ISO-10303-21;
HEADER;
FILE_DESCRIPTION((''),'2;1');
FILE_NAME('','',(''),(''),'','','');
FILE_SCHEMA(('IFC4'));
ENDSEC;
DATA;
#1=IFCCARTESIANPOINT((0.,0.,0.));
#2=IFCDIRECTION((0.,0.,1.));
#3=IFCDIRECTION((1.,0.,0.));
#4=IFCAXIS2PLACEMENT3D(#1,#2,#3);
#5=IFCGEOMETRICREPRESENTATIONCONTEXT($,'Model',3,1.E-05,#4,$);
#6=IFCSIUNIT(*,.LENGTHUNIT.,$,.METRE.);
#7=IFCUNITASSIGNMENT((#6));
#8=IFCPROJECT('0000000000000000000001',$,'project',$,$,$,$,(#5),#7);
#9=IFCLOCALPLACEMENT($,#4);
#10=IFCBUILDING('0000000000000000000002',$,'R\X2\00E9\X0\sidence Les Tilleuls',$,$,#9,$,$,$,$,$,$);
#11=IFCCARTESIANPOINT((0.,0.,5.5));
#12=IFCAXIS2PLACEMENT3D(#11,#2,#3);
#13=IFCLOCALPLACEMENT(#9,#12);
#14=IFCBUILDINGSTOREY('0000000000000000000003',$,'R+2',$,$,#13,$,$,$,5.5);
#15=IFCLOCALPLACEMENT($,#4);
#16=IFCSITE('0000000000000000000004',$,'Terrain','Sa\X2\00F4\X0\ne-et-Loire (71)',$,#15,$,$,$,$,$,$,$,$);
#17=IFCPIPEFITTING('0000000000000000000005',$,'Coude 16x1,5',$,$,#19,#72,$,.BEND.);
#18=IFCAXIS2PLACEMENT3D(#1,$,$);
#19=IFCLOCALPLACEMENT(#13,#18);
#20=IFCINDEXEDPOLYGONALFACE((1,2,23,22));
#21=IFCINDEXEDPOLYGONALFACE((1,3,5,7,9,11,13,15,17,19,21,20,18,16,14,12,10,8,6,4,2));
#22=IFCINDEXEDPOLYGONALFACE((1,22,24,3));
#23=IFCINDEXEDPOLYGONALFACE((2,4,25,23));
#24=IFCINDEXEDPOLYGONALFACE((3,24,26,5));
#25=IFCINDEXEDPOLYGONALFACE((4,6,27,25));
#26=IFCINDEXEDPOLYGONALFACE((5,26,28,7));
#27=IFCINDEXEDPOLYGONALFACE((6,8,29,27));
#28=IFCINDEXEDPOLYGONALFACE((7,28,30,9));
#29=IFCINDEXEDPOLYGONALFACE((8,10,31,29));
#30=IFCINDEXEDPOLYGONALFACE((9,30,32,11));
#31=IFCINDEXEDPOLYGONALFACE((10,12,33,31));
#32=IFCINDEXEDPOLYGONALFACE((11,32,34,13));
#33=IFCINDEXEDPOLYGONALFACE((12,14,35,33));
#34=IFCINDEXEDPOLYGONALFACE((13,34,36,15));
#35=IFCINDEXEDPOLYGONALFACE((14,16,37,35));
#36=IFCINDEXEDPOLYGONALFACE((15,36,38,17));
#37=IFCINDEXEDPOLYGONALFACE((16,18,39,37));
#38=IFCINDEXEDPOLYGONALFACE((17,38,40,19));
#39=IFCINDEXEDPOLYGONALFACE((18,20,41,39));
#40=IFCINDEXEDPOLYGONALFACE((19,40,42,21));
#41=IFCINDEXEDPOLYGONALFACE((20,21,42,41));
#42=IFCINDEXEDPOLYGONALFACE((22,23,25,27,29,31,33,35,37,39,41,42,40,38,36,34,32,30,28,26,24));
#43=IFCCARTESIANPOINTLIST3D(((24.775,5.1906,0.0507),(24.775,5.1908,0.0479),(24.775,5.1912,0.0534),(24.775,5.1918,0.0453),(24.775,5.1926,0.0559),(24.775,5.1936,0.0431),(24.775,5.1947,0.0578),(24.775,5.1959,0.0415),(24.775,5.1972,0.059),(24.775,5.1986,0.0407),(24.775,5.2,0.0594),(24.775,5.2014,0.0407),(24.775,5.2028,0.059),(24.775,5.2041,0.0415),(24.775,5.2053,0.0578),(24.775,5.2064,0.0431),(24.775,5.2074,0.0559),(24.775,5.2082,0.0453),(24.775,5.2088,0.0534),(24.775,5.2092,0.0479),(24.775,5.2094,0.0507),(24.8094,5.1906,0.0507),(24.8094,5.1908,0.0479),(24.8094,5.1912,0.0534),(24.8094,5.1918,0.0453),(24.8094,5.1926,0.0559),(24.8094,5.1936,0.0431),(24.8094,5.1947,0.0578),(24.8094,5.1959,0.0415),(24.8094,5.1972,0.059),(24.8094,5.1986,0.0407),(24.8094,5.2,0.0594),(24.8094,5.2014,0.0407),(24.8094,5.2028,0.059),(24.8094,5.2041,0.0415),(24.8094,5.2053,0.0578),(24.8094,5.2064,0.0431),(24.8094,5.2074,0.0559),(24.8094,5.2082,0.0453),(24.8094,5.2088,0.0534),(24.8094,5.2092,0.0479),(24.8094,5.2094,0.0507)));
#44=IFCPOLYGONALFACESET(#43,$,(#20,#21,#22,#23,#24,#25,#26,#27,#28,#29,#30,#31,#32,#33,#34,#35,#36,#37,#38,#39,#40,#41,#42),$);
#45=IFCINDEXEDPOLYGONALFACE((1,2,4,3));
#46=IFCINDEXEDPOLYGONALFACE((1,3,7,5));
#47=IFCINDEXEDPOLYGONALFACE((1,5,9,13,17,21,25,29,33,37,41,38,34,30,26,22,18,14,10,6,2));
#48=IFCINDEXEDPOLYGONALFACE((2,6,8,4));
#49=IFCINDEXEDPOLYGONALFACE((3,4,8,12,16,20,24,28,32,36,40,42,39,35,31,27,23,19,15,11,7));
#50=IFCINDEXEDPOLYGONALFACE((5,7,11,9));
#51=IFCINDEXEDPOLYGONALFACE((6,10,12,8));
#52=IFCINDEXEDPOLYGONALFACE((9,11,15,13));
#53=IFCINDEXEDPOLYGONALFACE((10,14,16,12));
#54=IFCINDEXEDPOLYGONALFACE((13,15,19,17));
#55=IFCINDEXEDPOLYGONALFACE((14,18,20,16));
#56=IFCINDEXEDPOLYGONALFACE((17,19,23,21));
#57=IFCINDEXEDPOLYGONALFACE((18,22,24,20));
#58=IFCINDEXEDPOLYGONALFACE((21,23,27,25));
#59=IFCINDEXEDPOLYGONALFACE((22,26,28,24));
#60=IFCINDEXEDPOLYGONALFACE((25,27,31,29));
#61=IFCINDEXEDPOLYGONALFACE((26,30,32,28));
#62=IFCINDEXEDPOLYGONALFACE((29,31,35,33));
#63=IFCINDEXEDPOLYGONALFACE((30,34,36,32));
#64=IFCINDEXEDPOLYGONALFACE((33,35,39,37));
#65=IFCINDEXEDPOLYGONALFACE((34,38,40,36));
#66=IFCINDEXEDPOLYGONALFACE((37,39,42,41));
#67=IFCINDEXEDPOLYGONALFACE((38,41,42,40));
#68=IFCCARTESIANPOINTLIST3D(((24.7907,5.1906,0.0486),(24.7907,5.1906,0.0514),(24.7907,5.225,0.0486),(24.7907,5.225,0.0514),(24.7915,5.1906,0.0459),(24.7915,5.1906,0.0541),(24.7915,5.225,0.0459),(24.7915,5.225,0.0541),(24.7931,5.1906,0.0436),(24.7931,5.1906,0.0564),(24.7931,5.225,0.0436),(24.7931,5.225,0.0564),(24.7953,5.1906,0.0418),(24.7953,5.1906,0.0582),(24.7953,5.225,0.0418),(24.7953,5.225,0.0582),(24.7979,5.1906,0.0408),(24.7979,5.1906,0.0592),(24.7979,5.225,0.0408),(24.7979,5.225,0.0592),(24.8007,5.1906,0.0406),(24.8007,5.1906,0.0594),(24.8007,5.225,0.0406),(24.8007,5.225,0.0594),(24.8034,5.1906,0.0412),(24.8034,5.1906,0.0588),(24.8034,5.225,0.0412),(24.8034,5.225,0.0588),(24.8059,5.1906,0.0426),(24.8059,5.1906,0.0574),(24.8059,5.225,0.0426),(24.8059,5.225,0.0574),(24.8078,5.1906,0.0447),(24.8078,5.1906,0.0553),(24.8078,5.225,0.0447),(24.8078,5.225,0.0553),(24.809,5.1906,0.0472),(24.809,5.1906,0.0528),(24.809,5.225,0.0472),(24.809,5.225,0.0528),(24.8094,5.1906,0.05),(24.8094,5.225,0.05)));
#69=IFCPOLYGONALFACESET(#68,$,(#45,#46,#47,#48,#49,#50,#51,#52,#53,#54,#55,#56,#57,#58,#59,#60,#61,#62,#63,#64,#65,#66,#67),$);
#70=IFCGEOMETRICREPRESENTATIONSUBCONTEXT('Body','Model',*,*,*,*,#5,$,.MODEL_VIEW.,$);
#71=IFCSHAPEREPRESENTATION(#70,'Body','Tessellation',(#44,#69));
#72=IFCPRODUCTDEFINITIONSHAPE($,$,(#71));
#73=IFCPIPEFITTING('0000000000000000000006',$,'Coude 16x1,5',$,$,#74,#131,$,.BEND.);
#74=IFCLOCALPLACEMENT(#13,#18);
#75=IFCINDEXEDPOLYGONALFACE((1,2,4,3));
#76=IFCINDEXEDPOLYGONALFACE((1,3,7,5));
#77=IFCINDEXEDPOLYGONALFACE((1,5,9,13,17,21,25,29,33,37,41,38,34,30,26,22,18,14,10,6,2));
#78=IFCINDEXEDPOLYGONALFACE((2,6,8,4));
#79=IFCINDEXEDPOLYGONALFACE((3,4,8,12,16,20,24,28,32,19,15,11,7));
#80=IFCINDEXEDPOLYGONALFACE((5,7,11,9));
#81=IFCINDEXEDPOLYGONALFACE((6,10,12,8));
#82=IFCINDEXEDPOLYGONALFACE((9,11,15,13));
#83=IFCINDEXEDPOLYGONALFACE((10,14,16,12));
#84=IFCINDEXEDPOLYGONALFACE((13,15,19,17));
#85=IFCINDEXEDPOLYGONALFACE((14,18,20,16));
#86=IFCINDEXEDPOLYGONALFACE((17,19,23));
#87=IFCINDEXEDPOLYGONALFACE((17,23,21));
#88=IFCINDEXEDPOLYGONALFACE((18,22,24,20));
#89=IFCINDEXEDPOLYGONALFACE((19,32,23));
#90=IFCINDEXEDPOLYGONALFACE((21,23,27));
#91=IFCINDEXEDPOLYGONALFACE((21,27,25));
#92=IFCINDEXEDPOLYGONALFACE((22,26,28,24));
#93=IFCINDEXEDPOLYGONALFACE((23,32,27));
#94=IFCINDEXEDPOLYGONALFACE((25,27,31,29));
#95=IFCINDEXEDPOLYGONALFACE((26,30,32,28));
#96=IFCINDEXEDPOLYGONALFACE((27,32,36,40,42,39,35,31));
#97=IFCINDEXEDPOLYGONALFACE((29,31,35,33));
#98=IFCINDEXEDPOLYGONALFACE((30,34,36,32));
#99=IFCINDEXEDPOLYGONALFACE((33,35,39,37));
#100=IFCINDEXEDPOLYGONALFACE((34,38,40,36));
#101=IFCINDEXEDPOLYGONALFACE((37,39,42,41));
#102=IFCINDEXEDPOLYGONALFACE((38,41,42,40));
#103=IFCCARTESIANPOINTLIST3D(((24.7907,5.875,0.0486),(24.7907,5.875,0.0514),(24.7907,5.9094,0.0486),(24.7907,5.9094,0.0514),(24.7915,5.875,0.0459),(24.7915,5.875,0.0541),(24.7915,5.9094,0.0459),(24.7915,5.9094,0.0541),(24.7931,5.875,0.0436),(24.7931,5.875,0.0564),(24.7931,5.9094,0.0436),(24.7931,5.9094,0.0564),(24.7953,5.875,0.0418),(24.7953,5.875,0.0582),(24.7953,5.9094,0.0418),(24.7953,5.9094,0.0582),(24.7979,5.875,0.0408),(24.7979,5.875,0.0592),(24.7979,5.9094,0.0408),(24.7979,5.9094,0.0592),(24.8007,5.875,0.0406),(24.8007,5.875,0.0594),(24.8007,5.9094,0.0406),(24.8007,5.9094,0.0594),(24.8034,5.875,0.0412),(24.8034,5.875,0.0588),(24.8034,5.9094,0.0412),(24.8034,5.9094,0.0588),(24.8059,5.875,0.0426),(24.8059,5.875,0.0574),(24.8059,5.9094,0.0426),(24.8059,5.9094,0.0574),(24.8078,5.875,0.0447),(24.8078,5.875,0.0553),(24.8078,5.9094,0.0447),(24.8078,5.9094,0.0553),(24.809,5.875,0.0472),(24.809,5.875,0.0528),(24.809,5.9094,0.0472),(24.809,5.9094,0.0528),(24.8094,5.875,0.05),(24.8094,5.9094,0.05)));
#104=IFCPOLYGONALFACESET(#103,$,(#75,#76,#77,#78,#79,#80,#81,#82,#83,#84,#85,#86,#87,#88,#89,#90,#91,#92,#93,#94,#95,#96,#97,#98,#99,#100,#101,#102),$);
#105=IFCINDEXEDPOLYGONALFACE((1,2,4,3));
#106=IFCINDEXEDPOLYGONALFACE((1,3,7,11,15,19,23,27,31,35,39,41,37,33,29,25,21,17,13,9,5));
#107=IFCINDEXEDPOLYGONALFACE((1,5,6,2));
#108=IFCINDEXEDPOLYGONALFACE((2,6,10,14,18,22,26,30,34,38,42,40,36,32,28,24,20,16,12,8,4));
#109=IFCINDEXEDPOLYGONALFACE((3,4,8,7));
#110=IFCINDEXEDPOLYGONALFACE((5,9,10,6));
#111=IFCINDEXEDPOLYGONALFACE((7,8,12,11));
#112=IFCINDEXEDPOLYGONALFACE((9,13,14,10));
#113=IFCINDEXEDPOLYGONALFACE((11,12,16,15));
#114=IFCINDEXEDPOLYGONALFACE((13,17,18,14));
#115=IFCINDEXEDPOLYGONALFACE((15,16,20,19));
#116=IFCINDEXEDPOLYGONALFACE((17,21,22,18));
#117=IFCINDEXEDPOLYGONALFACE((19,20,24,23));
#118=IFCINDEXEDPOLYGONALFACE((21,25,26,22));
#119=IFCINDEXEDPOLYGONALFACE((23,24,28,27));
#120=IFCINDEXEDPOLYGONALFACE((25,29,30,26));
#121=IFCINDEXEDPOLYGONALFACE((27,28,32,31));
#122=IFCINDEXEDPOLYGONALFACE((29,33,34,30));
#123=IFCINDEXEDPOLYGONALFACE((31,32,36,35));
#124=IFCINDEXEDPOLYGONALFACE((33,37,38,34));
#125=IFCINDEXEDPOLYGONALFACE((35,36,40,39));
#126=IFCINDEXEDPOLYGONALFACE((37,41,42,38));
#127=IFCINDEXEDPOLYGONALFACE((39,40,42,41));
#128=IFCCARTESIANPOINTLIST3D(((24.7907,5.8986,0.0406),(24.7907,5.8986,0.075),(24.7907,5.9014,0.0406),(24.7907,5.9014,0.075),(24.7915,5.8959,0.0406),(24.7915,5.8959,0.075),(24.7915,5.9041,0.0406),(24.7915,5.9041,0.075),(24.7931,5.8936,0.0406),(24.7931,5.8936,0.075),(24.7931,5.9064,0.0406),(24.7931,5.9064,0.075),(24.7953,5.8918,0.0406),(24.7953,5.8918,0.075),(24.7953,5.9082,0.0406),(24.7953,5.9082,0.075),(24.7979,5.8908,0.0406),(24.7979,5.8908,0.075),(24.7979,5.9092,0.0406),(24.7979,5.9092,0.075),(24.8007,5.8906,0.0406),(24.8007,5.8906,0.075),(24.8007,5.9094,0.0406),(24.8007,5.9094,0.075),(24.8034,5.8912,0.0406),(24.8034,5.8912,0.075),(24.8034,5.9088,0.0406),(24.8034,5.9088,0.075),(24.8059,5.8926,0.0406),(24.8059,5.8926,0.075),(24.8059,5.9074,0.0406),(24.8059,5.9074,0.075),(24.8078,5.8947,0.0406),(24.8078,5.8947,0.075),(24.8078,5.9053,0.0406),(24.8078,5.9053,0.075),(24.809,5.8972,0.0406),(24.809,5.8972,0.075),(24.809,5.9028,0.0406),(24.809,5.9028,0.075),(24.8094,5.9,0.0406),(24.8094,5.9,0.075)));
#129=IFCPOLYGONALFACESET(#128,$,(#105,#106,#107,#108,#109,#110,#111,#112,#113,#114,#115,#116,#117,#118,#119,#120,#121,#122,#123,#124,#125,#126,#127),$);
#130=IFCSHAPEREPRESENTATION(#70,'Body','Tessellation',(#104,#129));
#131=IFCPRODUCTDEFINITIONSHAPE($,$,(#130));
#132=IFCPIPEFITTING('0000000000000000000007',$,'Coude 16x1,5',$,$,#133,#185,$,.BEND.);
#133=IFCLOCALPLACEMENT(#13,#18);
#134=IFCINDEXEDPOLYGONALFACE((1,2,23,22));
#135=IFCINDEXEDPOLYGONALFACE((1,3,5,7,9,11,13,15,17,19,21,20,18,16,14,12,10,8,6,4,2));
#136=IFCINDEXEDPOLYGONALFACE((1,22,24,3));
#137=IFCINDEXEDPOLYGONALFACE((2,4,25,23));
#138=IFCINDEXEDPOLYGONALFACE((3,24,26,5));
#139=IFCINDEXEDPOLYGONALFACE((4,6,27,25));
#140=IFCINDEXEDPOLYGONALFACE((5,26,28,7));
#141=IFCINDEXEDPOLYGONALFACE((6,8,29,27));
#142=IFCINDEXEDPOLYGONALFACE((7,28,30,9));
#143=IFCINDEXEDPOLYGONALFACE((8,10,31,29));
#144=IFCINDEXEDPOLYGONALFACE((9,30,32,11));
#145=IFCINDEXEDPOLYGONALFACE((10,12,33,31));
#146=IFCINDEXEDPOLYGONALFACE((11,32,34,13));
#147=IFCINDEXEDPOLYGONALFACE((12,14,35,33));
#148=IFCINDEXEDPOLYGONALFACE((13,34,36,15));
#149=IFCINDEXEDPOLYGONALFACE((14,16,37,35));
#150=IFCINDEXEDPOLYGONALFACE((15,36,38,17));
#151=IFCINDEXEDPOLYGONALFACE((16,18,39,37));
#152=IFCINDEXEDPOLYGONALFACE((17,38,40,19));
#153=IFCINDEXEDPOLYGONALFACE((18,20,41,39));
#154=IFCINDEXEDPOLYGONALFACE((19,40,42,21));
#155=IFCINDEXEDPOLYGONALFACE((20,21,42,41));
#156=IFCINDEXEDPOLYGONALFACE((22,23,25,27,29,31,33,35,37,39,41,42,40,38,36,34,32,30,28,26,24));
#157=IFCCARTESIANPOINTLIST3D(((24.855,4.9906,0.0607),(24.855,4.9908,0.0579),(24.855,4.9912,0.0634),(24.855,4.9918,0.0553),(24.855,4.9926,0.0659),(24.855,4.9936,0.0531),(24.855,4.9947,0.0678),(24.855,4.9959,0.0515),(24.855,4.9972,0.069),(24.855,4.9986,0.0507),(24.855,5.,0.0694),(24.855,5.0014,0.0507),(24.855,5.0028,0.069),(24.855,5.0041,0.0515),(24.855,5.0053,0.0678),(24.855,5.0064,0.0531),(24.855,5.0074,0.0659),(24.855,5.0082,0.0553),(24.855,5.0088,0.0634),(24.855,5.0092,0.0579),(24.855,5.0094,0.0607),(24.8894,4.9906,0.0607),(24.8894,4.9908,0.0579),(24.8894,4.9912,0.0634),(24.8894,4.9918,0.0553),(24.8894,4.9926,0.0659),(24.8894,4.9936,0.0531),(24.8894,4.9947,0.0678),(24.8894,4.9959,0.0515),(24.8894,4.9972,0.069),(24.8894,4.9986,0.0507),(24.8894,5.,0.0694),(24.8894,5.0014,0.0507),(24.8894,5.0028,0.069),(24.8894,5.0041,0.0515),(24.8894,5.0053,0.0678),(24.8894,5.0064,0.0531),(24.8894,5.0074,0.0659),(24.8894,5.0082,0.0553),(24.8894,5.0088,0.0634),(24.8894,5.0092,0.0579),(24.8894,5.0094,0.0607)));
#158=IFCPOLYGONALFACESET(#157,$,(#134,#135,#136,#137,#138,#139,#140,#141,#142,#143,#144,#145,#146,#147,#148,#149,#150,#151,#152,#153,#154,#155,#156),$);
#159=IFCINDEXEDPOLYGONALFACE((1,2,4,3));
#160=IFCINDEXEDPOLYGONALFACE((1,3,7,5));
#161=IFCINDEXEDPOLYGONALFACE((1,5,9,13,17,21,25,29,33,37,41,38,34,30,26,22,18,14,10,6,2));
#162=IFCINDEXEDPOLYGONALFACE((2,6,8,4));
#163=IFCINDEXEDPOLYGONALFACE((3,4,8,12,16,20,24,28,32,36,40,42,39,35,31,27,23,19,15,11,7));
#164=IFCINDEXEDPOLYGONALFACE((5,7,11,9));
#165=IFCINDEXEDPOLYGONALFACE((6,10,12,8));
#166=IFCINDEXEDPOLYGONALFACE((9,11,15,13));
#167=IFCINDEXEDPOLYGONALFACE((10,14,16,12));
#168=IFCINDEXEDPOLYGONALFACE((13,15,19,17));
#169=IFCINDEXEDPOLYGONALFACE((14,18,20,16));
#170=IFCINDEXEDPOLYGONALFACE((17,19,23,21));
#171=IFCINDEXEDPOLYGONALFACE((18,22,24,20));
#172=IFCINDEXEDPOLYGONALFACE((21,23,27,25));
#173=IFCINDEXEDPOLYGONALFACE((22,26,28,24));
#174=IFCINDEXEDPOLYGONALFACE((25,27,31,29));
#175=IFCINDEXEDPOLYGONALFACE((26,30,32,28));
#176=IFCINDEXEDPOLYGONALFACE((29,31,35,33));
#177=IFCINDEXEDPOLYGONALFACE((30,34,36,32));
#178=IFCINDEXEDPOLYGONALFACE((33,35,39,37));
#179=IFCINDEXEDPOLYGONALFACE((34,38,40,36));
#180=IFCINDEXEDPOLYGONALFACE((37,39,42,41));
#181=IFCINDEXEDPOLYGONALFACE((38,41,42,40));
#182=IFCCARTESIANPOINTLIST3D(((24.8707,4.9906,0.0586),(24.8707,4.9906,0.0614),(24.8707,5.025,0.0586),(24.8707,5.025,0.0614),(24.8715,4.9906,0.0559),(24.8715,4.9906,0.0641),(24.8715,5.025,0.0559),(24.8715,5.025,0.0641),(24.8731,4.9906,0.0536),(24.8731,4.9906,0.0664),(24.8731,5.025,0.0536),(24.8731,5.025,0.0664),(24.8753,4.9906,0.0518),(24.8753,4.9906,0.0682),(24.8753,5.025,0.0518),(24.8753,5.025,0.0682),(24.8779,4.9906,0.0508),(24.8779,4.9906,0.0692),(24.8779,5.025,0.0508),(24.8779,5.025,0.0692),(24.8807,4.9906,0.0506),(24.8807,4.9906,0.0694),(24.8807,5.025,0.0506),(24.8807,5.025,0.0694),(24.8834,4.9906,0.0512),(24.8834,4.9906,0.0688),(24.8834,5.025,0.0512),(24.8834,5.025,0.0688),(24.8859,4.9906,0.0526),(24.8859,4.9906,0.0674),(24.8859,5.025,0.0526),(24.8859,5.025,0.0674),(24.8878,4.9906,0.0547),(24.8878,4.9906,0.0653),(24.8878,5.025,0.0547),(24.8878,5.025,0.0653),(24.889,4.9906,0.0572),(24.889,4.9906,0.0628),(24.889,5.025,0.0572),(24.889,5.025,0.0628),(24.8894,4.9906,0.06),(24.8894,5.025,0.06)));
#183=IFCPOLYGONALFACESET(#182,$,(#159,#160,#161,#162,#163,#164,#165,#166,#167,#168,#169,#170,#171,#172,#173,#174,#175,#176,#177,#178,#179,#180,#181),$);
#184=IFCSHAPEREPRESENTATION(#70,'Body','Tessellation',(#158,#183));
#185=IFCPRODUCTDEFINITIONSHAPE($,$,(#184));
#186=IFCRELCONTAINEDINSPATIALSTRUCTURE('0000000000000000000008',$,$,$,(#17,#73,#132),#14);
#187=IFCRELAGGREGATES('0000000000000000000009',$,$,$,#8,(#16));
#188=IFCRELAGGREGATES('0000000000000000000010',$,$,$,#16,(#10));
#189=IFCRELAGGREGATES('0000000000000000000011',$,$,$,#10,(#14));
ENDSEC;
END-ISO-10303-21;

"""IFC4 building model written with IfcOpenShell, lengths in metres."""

from ifc_helpers import new_model, si_unit, frame, origin_with_axes, place, context, subcontext, project, spatial, circle, extrude, element, save


model = new_model("IFC4")

# Units and contexts
model_context = context("Model", 3, precision=1e-05, world=origin_with_axes())
body_context = subcontext(model_context, "Body", "Model", "MODEL_VIEW")
ifc_project = project(units=[si_unit("LENGTHUNIT", "METRE")], contexts=[model_context])

# Site, building, storey
site_placement = place(None, origin_with_axes())
site = spatial("IfcSite", under=ifc_project, at=site_placement, Name="Terrain", Description="Saône-et-Loire (71)")
building_placement = place(None, origin_with_axes())
building = spatial("IfcBuilding", under=site, at=building_placement, Name="Résidence Les Tilleuls")
storey_placement = place(building_placement, frame((0.0, 0.0, 5.5), z_axis=(0.0, 0.0, 1.0), x_axis=(1.0, 0.0, 0.0)))
storey = spatial("IfcBuildingStorey", under=building, at=storey_placement, Name="R+2", Elevation=5.5)

# Pipe fittings
pipe_fitting_1_placement = place(storey_placement, frame((24.8, 5.2, 0.05), z_axis=(0.0, 0.0, 1.0), x_axis=(1.0, 0.0, 0.0)))
element("IfcPipeFitting", 1, at=pipe_fitting_1_placement, inside=storey, Name="Coude 16x1,5", PredefinedType="BEND", context=body_context, shape_type="SweptSolid", body=[
    extrude(circle(Radius=0.0094), frame((0.0094, 0.0, 0.0), z_axis=(-1.0, 0.0, 0.0), x_axis=(0.0, 0.0, 1.0)), (0.0, 0.0, 1.0), 0.0344),
    extrude(circle(Radius=0.0094), frame((0.0, -0.0094, 0.0), z_axis=(0.0, 1.0, 0.0), x_axis=(1.0, 0.0, 0.0)), (0.0, 0.0, 1.0), 0.0344),
])
pipe_fitting_2_placement = place(storey_placement, frame((24.8, 5.9, 0.05), z_axis=(0.0, 0.0, 1.0), x_axis=(1.0, 0.0, 0.0)))
element("IfcPipeFitting", 2, at=pipe_fitting_2_placement, inside=storey, Name="Coude 16x1,5", PredefinedType="BEND", context=body_context, shape_type="SweptSolid", body=[
    extrude(circle(Radius=0.0094), frame((0.0, 0.0094, 0.0), z_axis=(0.0, -1.0, 0.0), x_axis=(1.0, 0.0, 0.0)), (0.0, 0.0, 1.0), 0.0344),
    extrude(circle(Radius=0.0094), frame((0.0, 0.0, -0.0094), z_axis=(0.0, 0.0, 1.0), x_axis=(1.0, 0.0, 0.0)), (0.0, 0.0, 1.0), 0.0344),
])
pipe_fitting_3_placement = place(storey_placement, frame((24.88, 5.0, 0.06), z_axis=(0.0, 0.0, 1.0), x_axis=(1.0, 0.0, 0.0)))
element("IfcPipeFitting", 3, at=pipe_fitting_3_placement, inside=storey, Name="Coude 16x1,5", PredefinedType="BEND", context=body_context, shape_type="SweptSolid", body=[
    extrude(circle(Radius=0.0094), frame((0.0094, 0.0, 0.0), z_axis=(-1.0, 0.0, 0.0), x_axis=(0.0, 0.0, 1.0)), (0.0, 0.0, 1.0), 0.0344),
    extrude(circle(Radius=0.0094), frame((0.0, -0.0094, 0.0), z_axis=(0.0, 1.0, 0.0), x_axis=(1.0, 0.0, 0.0)), (0.0, 0.0, 1.0), 0.0344),
])

save(model, "model.ifc")
